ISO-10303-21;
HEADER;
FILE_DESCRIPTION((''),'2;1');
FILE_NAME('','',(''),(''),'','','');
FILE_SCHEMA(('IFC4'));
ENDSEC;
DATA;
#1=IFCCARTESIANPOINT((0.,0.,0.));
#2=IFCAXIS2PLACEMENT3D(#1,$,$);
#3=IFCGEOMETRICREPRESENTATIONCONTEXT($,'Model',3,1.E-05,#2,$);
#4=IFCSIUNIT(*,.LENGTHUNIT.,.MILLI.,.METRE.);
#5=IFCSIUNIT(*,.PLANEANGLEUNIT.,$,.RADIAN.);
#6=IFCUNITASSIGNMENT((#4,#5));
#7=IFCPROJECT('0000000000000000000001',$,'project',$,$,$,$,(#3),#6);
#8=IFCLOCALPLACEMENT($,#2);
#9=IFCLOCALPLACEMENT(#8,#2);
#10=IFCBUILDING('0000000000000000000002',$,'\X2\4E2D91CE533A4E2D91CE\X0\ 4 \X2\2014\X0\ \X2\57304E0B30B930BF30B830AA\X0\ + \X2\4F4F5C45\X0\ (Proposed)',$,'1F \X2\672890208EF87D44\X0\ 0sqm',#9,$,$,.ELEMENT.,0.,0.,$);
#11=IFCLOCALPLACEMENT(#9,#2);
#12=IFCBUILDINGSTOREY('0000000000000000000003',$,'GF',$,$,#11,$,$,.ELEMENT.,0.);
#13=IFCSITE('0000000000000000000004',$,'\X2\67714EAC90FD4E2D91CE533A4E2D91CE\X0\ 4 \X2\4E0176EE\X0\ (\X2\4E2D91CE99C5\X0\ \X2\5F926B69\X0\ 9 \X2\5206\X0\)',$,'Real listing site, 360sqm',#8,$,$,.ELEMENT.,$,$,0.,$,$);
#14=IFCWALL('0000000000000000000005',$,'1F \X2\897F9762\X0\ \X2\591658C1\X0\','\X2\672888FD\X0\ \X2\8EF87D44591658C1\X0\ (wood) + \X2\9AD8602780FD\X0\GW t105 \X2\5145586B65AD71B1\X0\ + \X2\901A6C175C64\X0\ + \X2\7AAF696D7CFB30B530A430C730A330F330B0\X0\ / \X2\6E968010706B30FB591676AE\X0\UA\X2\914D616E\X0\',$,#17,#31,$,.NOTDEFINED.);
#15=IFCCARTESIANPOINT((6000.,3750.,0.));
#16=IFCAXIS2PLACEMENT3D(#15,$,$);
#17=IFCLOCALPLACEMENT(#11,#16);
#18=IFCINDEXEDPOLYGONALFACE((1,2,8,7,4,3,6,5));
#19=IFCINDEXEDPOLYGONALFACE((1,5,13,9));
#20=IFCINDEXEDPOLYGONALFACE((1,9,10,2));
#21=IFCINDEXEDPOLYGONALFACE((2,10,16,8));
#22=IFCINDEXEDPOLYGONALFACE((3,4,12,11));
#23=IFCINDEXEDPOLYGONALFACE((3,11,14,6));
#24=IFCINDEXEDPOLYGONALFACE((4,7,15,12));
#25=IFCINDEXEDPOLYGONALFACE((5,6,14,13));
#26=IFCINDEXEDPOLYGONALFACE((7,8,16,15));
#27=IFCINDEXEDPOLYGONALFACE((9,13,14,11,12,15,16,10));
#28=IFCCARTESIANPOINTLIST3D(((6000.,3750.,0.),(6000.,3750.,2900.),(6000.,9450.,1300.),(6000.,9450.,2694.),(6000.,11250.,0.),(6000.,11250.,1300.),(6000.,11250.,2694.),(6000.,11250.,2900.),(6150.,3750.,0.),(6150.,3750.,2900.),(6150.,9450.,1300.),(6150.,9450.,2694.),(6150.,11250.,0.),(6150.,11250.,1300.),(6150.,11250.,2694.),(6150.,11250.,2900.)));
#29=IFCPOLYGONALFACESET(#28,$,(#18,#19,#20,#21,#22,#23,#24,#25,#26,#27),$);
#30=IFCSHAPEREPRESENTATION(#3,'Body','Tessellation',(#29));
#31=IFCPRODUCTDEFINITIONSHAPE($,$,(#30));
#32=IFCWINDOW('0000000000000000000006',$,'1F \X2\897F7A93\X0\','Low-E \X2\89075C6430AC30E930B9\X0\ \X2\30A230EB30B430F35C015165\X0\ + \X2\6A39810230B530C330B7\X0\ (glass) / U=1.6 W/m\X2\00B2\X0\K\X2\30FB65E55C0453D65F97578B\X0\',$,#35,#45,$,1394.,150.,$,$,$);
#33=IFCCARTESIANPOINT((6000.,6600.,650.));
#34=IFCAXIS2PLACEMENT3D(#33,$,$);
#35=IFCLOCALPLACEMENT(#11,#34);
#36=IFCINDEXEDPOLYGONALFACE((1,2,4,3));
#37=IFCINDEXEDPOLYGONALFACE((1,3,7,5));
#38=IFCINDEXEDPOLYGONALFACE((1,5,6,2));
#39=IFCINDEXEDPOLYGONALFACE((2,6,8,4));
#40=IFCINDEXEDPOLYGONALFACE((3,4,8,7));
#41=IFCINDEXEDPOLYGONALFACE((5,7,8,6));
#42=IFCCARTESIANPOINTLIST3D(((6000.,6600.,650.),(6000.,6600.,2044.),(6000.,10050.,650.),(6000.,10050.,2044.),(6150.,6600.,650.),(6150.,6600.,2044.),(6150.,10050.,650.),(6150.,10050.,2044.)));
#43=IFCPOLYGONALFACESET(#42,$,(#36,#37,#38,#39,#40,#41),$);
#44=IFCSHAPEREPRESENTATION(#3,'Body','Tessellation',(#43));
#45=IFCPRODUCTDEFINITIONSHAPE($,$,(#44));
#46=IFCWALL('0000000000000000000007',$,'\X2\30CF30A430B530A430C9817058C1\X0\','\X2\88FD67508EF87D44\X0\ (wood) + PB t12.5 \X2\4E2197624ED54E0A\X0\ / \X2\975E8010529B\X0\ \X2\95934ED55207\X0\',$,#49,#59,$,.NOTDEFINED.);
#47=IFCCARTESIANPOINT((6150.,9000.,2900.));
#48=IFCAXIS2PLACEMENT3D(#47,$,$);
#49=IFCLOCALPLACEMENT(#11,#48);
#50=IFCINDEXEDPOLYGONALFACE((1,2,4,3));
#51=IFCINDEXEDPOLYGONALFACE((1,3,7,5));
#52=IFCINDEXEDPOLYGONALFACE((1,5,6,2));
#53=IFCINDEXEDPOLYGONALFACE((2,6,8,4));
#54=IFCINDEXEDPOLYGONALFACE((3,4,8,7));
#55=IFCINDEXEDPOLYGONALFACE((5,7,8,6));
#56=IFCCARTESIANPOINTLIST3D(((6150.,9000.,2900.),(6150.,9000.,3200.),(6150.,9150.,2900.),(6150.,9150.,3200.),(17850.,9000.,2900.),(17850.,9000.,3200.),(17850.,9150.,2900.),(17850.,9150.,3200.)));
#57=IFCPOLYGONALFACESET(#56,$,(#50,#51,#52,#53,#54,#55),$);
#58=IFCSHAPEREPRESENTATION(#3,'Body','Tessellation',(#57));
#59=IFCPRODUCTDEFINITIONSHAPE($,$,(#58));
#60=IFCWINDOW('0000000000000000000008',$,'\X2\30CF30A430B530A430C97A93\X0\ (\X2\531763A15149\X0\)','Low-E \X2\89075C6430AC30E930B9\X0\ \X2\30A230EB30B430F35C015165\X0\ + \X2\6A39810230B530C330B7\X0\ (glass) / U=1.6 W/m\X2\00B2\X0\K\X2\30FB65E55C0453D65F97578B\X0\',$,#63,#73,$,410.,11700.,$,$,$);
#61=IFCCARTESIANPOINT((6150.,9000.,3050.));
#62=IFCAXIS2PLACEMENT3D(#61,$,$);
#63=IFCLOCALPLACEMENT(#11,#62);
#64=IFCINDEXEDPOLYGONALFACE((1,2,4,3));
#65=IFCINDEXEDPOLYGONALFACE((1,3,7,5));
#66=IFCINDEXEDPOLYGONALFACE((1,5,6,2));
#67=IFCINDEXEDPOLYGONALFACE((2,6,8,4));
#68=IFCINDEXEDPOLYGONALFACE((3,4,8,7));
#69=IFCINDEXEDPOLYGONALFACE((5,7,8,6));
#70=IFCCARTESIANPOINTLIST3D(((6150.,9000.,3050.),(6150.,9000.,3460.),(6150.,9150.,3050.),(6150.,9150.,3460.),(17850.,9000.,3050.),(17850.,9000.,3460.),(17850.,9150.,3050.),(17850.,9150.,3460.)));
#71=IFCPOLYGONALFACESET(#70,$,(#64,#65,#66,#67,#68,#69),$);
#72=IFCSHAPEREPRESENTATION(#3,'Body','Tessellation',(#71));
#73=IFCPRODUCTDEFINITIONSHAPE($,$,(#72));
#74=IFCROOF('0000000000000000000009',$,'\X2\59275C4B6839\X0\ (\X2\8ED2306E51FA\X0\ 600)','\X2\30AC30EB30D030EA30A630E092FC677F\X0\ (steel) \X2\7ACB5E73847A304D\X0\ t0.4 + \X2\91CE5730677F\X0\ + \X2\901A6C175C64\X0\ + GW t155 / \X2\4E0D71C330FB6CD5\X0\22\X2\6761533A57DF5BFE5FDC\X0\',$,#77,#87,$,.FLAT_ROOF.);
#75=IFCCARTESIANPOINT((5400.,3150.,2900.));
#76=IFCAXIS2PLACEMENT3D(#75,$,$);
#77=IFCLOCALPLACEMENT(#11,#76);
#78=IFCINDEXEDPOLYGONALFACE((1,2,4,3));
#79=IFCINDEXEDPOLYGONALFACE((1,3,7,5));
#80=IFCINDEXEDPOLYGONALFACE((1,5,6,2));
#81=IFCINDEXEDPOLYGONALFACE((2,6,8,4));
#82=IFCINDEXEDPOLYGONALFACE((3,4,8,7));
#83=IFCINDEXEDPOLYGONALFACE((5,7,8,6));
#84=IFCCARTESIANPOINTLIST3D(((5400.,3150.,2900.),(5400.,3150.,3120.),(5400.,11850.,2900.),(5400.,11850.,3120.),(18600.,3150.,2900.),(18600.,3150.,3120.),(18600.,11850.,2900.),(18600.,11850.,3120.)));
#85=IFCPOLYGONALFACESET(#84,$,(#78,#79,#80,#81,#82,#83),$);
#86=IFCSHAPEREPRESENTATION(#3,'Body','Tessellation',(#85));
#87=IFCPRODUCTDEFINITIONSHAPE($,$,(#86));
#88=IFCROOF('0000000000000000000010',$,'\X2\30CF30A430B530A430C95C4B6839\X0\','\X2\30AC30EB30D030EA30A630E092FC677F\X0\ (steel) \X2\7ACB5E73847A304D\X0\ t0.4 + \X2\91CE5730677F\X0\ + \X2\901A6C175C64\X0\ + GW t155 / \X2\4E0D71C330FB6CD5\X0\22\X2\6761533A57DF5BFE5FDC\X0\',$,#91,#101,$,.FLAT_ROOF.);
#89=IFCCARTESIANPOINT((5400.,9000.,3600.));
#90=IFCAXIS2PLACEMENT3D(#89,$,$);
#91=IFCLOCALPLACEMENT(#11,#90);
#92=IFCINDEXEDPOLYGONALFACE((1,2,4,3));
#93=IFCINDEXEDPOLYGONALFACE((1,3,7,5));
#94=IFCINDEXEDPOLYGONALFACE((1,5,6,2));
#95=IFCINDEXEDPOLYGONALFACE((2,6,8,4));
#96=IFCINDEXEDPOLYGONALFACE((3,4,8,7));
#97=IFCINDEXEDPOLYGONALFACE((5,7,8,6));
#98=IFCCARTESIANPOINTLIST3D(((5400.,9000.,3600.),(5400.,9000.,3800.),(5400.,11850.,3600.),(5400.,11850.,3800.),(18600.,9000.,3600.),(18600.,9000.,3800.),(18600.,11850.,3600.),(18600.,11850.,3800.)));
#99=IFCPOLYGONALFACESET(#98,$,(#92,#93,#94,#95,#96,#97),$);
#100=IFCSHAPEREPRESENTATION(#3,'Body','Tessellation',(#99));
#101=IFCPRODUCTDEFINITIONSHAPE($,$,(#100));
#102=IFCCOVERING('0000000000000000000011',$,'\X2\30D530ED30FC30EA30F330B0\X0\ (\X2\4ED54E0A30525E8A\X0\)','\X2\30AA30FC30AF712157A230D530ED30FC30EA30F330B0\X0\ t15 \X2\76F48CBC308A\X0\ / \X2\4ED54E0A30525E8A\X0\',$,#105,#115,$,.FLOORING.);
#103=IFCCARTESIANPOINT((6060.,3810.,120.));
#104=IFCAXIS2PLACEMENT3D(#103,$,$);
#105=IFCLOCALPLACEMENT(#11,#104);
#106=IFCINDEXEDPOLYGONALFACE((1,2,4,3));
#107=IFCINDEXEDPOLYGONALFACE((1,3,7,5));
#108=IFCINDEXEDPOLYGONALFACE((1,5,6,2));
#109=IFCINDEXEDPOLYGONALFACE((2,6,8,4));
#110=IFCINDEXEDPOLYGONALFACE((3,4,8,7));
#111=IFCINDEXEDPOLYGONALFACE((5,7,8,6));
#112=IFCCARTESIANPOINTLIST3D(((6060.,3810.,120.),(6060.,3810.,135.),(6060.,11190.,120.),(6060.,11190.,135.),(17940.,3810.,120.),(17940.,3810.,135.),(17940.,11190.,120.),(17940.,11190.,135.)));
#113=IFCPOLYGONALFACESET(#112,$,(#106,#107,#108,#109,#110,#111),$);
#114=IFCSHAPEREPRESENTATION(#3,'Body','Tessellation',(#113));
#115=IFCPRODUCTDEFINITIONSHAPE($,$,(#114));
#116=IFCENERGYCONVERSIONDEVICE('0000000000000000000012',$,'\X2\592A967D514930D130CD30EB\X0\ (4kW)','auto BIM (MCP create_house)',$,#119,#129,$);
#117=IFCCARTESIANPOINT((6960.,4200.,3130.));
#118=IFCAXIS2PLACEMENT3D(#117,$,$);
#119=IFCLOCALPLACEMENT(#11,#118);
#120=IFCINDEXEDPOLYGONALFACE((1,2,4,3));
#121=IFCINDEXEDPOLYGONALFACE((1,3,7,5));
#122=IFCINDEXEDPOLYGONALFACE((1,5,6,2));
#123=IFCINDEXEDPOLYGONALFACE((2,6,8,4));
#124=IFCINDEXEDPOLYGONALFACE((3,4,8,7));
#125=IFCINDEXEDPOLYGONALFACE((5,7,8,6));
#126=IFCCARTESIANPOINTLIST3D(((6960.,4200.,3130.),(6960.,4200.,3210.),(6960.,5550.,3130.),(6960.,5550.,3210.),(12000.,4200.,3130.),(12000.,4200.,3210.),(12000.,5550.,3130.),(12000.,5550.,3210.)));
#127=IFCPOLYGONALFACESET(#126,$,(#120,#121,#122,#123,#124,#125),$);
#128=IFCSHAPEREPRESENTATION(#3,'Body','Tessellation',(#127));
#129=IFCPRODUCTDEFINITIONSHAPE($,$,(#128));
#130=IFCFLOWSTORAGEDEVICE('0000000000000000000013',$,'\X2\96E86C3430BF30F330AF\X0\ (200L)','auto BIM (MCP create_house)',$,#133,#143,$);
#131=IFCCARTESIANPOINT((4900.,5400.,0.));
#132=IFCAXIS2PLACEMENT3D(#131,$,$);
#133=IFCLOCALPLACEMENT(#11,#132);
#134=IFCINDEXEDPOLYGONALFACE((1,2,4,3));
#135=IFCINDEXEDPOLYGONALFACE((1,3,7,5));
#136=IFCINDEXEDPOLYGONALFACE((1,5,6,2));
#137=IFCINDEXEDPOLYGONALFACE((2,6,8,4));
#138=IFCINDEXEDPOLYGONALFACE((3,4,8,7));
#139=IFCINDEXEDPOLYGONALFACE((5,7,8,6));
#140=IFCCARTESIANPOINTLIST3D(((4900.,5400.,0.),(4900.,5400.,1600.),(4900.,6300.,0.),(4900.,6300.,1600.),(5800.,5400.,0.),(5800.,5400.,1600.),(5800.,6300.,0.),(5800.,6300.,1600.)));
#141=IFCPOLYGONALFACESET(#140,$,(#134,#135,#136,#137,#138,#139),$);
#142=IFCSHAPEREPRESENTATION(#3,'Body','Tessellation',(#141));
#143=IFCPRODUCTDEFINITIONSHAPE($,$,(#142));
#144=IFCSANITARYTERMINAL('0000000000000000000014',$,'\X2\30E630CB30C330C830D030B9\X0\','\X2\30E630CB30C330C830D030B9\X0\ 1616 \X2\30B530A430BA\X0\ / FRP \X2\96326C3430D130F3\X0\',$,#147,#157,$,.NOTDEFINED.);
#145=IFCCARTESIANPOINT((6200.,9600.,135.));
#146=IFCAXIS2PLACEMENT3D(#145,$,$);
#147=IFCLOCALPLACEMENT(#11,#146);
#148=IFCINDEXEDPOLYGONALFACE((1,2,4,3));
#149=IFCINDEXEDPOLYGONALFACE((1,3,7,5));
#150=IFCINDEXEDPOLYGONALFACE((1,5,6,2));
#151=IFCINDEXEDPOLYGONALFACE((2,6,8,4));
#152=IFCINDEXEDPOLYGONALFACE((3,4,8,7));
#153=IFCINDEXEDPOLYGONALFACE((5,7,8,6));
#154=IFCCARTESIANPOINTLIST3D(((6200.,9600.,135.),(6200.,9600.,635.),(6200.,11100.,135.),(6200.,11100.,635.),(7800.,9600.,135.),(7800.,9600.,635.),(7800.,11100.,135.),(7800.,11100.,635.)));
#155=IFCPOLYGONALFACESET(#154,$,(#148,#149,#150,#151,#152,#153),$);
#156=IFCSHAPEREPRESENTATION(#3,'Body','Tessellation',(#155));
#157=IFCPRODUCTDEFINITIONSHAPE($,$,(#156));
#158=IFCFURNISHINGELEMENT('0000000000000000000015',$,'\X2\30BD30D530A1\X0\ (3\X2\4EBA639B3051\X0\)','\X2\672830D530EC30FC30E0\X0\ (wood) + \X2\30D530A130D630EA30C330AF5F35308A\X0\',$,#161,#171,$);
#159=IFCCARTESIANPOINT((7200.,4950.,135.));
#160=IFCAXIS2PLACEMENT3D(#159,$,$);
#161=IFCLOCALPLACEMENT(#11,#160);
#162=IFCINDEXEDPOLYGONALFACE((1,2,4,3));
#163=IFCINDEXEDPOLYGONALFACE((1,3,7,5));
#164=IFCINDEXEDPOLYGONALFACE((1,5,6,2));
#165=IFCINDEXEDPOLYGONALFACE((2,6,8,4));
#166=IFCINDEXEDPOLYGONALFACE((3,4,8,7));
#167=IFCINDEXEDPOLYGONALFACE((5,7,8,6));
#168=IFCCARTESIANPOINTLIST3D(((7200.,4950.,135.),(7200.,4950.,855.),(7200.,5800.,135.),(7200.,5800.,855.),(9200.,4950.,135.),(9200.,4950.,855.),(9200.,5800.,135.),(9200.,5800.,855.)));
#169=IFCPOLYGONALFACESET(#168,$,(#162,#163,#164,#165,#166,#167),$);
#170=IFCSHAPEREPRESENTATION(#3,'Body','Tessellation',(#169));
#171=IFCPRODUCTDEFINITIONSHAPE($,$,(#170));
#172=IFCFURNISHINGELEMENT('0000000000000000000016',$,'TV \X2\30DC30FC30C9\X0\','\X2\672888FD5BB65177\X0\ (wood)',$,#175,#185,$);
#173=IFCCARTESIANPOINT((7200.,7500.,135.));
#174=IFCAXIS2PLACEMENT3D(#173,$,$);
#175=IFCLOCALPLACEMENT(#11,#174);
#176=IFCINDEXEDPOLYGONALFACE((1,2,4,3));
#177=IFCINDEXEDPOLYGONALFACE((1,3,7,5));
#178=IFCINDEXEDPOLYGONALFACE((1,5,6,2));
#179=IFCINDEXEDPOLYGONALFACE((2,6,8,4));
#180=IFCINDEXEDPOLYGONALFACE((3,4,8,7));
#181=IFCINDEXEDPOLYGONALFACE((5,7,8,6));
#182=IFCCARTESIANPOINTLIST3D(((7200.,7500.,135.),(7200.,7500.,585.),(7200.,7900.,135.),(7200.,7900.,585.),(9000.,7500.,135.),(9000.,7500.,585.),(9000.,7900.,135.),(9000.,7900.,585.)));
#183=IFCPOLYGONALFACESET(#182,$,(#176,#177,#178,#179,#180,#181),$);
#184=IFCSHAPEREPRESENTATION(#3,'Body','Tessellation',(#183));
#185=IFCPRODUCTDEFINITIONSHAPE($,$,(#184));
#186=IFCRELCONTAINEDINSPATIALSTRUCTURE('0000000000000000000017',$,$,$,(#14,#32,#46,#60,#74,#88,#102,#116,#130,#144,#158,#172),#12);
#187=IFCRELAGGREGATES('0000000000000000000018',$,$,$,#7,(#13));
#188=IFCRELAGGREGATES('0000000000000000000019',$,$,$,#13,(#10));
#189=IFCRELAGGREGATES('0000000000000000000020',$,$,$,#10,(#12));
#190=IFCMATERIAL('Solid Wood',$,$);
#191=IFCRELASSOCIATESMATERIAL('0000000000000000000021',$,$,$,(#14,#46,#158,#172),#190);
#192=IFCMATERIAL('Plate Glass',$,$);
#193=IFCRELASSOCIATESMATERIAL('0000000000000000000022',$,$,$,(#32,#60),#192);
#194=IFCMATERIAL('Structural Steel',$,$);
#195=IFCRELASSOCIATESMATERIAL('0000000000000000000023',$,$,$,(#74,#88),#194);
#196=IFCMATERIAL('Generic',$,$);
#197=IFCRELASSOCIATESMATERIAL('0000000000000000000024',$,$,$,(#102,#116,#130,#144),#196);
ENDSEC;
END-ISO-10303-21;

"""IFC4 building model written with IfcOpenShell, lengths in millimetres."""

from ifc_helpers import new_model, si_unit, frame, frame_2d, origin, place, context, project, spatial, rectangle, extrude, material, element, fill, save


model = new_model("IFC4")

# Units and contexts
model_context = context("Model", 3, precision=1e-05, world=origin())
ifc_project = project(units=[si_unit("LENGTHUNIT", "METRE", prefix="MILLI"), si_unit("PLANEANGLEUNIT", "RADIAN")], contexts=[model_context])

# Site, building, storey
site_placement = place(None, origin())
site = spatial("IfcSite", under=ifc_project, at=site_placement, Name="東京都中野区中野 4 丁目 (中野駅 徒歩 9 分)", ObjectType="Real listing site, 360sqm", CompositionType="ELEMENT", RefElevation=0.0)
building_placement = place(site_placement, origin())
building = spatial("IfcBuilding", under=site, at=building_placement, Name="中野区中野 4 — 地下スタジオ + 住居 (Proposed)", ObjectType="1F 木造軸組 0sqm", CompositionType="ELEMENT", ElevationOfRefHeight=0.0, ElevationOfTerrain=0.0)
storey_placement = place(building_placement, origin())
storey = spatial("IfcBuildingStorey", under=building, at=storey_placement, Name="GF", CompositionType="ELEMENT", Elevation=0.0)

# Shared definitions
ifc_material_1 = material(Name="Solid Wood")

# Shared definitions
ifc_material_2 = material(Name="Plate Glass")

# Wall, opening, window
wall_1_placement = place(storey_placement, frame((6000.0, 3750.0, 0.0)))
wall_1 = element("IfcWall", 1, at=wall_1_placement, inside=storey, material=ifc_material_1, Name="1F 西面 外壁", Description="木製 軸組外壁 (wood) + 高性能GW t105 充填断熱 + 通気層 + 窯業系サイディング / 準耐火・外皮UA配慮", PredefinedType="NOTDEFINED", context=model_context, shape_type="SweptSolid", body=[
    extrude(rectangle(XDim=150.0, YDim=7500.0, at=frame_2d((75.0, 3750.0))), frame((6000.0, 3750.0, 0.0)), (0.0, 0.0, 1.0), 2900.0),
])
opening_1_placement = place(storey_placement, frame((6000.0, 6600.0, 650.0)))
opening_1 = element("IfcOpeningElement", 2, at=opening_1_placement, cuts=wall_1, PredefinedType="NOTDEFINED", context=model_context, shape_type="SweptSolid", body=[
    extrude(rectangle(XDim=150.0, YDim=3450.0, at=frame_2d((75.0, 1725.0))), frame((6000.0, 6600.0, 650.0)), (0.0, 0.0, 1.0), 1394.0),
])
window_1_placement = place(storey_placement, frame((6000.0, 6600.0, 650.0)))
window_1 = element("IfcWindow", 3, at=window_1_placement, inside=storey, material=ifc_material_2, Name="1F 西窓", Description="Low-E 複層ガラス アルゴン封入 + 樹脂サッシ (glass) / U=1.6 W/m²K・日射取得型", OverallHeight=1394.0, OverallWidth=150.0, context=model_context, shape_type="SweptSolid", body=[
    extrude(rectangle(XDim=150.0, YDim=3450.0, at=frame_2d((75.0, 1725.0))), frame((6000.0, 6600.0, 650.0)), (0.0, 0.0, 1.0), 1394.0),
])
fill(opening_1, window_1)

# Wall, opening, window
wall_2_placement = place(storey_placement, frame((6150.0, 9000.0, 2900.0)))
wall_2 = element("IfcWall", 4, at=wall_2_placement, inside=storey, material=ifc_material_1, Name="ハイサイド腰壁", Description="製材軸組 (wood) + PB t12.5 両面仕上 / 非耐力 間仕切", PredefinedType="NOTDEFINED", context=model_context, shape_type="SweptSolid", body=[
    extrude(rectangle(XDim=11700.0, YDim=150.0, at=frame_2d((5850.0, 75.0))), frame((6150.0, 9000.0, 2900.0)), (0.0, 0.0, 1.0), 700.0),
])
opening_2_placement = place(storey_placement, frame((6150.0, 9000.0, 3050.0)))
opening_2 = element("IfcOpeningElement", 5, at=opening_2_placement, cuts=wall_2, PredefinedType="NOTDEFINED", context=model_context, shape_type="SweptSolid", body=[
    extrude(rectangle(XDim=11700.0, YDim=150.0, at=frame_2d((5850.0, 75.0))), frame((6150.0, 9000.0, 3050.0)), (0.0, 0.0, 1.0), 410.0),
])
window_2_placement = place(storey_placement, frame((6150.0, 9000.0, 3050.0)))
window_2 = element("IfcWindow", 6, at=window_2_placement, inside=storey, material=ifc_material_2, Name="ハイサイド窓 (北採光)", Description="Low-E 複層ガラス アルゴン封入 + 樹脂サッシ (glass) / U=1.6 W/m²K・日射取得型", OverallHeight=410.0, OverallWidth=11700.0, context=model_context, shape_type="SweptSolid", body=[
    extrude(rectangle(XDim=11700.0, YDim=150.0, at=frame_2d((5850.0, 75.0))), frame((6150.0, 9000.0, 3050.0)), (0.0, 0.0, 1.0), 410.0),
])
fill(opening_2, window_2)

# Roofs
ifc_material_3 = material(Name="Structural Steel")
roof_1_placement = place(storey_placement, frame((5400.0, 3150.0, 2900.0)))
element("IfcRoof", 7, at=roof_1_placement, inside=storey, material=ifc_material_3, Name="大屋根 (軒の出 600)", Description="ガルバリウム鋼板 (steel) 立平葺き t0.4 + 野地板 + 通気層 + GW t155 / 不燃・法22条区域対応", PredefinedType="FLAT_ROOF", context=model_context, shape_type="SweptSolid", body=[
    extrude(rectangle(XDim=13200.0, YDim=8700.0, at=frame_2d((6600.0, 4350.0))), frame((5400.0, 3150.0, 2900.0)), (0.0, 0.0, 1.0), 220.0),
])
roof_2_placement = place(storey_placement, frame((5400.0, 9000.0, 3600.0)))
element("IfcRoof", 8, at=roof_2_placement, inside=storey, material=ifc_material_3, Name="ハイサイド屋根", Description="ガルバリウム鋼板 (steel) 立平葺き t0.4 + 野地板 + 通気層 + GW t155 / 不燃・法22条区域対応", PredefinedType="FLAT_ROOF", context=model_context, shape_type="SweptSolid", body=[
    extrude(rectangle(XDim=13200.0, YDim=2850.0, at=frame_2d((6600.0, 1425.0))), frame((5400.0, 9000.0, 3600.0)), (0.0, 0.0, 1.0), 200.0),
])

# Covering
ifc_material_4 = material(Name="Generic")
covering_placement = place(storey_placement, frame((6060.0, 3810.0, 120.0)))
element("IfcCovering", 9, at=covering_placement, inside=storey, material=ifc_material_4, Name="フローリング (仕上げ床)", Description="オーク無垢フローリング t15 直貼り / 仕上げ床", PredefinedType="FLOORING", context=model_context, shape_type="SweptSolid", body=[
    extrude(rectangle(XDim=11880.0, YDim=7380.0, at=frame_2d((5940.0, 3690.0))), frame((6060.0, 3810.0, 120.0)), (0.0, 0.0, 1.0), 15.0),
])

# Energy conversion device
energy_conversion_device_placement = place(storey_placement, frame((6960.0, 4200.0, 3130.0)))
element("IfcEnergyConversionDevice", 10, at=energy_conversion_device_placement, inside=storey, material=ifc_material_4, Name="太陽光パネル (4kW)", Description="auto BIM (MCP create_house)", context=model_context, shape_type="SweptSolid", body=[
    extrude(rectangle(XDim=5040.0, YDim=1350.0, at=frame_2d((2520.0, 675.0))), frame((6960.0, 4200.0, 3130.0)), (0.0, 0.0, 1.0), 80.0),
])

# Flow storage device
flow_storage_device_placement = place(storey_placement, frame((4900.0, 5400.0, 0.0)))
element("IfcFlowStorageDevice", 11, at=flow_storage_device_placement, inside=storey, material=ifc_material_4, Name="雨水タンク (200L)", Description="auto BIM (MCP create_house)", context=model_context, shape_type="SweptSolid", body=[
    extrude(rectangle(XDim=900.0, YDim=900.0, at=frame_2d((450.0, 450.0))), frame((4900.0, 5400.0, 0.0)), (0.0, 0.0, 1.0), 1600.0),
])

# Sanitary terminal
sanitary_terminal_placement = place(storey_placement, frame((6200.0, 9600.0, 135.0)))
element("IfcSanitaryTerminal", 12, at=sanitary_terminal_placement, inside=storey, material=ifc_material_4, Name="ユニットバス", Description="ユニットバス 1616 サイズ / FRP 防水パン", PredefinedType="NOTDEFINED", context=model_context, shape_type="SweptSolid", body=[
    extrude(rectangle(XDim=1600.0, YDim=1500.0, at=frame_2d((800.0, 750.0))), frame((6200.0, 9600.0, 135.0)), (0.0, 0.0, 1.0), 500.0),
])

# Furnishing elements
furnishing_1_placement = place(storey_placement, frame((7200.0, 4950.0, 135.0)))
element("IfcFurnishingElement", 13, at=furnishing_1_placement, inside=storey, material=ifc_material_1, Name="ソファ (3人掛け)", Description="木フレーム (wood) + ファブリック張り", context=model_context, shape_type="SweptSolid", body=[
    extrude(rectangle(XDim=2000.0, YDim=850.0, at=frame_2d((1000.0, 425.0))), frame((7200.0, 4950.0, 135.0)), (0.0, 0.0, 1.0), 720.0),
])
furnishing_2_placement = place(storey_placement, frame((7200.0, 7500.0, 135.0)))
element("IfcFurnishingElement", 14, at=furnishing_2_placement, inside=storey, material=ifc_material_1, Name="TV ボード", Description="木製家具 (wood)", context=model_context, shape_type="SweptSolid", body=[
    extrude(rectangle(XDim=1800.0, YDim=400.0, at=frame_2d((900.0, 200.0))), frame((7200.0, 7500.0, 135.0)), (0.0, 0.0, 1.0), 450.0),
])

save(model, "model.ifc")
